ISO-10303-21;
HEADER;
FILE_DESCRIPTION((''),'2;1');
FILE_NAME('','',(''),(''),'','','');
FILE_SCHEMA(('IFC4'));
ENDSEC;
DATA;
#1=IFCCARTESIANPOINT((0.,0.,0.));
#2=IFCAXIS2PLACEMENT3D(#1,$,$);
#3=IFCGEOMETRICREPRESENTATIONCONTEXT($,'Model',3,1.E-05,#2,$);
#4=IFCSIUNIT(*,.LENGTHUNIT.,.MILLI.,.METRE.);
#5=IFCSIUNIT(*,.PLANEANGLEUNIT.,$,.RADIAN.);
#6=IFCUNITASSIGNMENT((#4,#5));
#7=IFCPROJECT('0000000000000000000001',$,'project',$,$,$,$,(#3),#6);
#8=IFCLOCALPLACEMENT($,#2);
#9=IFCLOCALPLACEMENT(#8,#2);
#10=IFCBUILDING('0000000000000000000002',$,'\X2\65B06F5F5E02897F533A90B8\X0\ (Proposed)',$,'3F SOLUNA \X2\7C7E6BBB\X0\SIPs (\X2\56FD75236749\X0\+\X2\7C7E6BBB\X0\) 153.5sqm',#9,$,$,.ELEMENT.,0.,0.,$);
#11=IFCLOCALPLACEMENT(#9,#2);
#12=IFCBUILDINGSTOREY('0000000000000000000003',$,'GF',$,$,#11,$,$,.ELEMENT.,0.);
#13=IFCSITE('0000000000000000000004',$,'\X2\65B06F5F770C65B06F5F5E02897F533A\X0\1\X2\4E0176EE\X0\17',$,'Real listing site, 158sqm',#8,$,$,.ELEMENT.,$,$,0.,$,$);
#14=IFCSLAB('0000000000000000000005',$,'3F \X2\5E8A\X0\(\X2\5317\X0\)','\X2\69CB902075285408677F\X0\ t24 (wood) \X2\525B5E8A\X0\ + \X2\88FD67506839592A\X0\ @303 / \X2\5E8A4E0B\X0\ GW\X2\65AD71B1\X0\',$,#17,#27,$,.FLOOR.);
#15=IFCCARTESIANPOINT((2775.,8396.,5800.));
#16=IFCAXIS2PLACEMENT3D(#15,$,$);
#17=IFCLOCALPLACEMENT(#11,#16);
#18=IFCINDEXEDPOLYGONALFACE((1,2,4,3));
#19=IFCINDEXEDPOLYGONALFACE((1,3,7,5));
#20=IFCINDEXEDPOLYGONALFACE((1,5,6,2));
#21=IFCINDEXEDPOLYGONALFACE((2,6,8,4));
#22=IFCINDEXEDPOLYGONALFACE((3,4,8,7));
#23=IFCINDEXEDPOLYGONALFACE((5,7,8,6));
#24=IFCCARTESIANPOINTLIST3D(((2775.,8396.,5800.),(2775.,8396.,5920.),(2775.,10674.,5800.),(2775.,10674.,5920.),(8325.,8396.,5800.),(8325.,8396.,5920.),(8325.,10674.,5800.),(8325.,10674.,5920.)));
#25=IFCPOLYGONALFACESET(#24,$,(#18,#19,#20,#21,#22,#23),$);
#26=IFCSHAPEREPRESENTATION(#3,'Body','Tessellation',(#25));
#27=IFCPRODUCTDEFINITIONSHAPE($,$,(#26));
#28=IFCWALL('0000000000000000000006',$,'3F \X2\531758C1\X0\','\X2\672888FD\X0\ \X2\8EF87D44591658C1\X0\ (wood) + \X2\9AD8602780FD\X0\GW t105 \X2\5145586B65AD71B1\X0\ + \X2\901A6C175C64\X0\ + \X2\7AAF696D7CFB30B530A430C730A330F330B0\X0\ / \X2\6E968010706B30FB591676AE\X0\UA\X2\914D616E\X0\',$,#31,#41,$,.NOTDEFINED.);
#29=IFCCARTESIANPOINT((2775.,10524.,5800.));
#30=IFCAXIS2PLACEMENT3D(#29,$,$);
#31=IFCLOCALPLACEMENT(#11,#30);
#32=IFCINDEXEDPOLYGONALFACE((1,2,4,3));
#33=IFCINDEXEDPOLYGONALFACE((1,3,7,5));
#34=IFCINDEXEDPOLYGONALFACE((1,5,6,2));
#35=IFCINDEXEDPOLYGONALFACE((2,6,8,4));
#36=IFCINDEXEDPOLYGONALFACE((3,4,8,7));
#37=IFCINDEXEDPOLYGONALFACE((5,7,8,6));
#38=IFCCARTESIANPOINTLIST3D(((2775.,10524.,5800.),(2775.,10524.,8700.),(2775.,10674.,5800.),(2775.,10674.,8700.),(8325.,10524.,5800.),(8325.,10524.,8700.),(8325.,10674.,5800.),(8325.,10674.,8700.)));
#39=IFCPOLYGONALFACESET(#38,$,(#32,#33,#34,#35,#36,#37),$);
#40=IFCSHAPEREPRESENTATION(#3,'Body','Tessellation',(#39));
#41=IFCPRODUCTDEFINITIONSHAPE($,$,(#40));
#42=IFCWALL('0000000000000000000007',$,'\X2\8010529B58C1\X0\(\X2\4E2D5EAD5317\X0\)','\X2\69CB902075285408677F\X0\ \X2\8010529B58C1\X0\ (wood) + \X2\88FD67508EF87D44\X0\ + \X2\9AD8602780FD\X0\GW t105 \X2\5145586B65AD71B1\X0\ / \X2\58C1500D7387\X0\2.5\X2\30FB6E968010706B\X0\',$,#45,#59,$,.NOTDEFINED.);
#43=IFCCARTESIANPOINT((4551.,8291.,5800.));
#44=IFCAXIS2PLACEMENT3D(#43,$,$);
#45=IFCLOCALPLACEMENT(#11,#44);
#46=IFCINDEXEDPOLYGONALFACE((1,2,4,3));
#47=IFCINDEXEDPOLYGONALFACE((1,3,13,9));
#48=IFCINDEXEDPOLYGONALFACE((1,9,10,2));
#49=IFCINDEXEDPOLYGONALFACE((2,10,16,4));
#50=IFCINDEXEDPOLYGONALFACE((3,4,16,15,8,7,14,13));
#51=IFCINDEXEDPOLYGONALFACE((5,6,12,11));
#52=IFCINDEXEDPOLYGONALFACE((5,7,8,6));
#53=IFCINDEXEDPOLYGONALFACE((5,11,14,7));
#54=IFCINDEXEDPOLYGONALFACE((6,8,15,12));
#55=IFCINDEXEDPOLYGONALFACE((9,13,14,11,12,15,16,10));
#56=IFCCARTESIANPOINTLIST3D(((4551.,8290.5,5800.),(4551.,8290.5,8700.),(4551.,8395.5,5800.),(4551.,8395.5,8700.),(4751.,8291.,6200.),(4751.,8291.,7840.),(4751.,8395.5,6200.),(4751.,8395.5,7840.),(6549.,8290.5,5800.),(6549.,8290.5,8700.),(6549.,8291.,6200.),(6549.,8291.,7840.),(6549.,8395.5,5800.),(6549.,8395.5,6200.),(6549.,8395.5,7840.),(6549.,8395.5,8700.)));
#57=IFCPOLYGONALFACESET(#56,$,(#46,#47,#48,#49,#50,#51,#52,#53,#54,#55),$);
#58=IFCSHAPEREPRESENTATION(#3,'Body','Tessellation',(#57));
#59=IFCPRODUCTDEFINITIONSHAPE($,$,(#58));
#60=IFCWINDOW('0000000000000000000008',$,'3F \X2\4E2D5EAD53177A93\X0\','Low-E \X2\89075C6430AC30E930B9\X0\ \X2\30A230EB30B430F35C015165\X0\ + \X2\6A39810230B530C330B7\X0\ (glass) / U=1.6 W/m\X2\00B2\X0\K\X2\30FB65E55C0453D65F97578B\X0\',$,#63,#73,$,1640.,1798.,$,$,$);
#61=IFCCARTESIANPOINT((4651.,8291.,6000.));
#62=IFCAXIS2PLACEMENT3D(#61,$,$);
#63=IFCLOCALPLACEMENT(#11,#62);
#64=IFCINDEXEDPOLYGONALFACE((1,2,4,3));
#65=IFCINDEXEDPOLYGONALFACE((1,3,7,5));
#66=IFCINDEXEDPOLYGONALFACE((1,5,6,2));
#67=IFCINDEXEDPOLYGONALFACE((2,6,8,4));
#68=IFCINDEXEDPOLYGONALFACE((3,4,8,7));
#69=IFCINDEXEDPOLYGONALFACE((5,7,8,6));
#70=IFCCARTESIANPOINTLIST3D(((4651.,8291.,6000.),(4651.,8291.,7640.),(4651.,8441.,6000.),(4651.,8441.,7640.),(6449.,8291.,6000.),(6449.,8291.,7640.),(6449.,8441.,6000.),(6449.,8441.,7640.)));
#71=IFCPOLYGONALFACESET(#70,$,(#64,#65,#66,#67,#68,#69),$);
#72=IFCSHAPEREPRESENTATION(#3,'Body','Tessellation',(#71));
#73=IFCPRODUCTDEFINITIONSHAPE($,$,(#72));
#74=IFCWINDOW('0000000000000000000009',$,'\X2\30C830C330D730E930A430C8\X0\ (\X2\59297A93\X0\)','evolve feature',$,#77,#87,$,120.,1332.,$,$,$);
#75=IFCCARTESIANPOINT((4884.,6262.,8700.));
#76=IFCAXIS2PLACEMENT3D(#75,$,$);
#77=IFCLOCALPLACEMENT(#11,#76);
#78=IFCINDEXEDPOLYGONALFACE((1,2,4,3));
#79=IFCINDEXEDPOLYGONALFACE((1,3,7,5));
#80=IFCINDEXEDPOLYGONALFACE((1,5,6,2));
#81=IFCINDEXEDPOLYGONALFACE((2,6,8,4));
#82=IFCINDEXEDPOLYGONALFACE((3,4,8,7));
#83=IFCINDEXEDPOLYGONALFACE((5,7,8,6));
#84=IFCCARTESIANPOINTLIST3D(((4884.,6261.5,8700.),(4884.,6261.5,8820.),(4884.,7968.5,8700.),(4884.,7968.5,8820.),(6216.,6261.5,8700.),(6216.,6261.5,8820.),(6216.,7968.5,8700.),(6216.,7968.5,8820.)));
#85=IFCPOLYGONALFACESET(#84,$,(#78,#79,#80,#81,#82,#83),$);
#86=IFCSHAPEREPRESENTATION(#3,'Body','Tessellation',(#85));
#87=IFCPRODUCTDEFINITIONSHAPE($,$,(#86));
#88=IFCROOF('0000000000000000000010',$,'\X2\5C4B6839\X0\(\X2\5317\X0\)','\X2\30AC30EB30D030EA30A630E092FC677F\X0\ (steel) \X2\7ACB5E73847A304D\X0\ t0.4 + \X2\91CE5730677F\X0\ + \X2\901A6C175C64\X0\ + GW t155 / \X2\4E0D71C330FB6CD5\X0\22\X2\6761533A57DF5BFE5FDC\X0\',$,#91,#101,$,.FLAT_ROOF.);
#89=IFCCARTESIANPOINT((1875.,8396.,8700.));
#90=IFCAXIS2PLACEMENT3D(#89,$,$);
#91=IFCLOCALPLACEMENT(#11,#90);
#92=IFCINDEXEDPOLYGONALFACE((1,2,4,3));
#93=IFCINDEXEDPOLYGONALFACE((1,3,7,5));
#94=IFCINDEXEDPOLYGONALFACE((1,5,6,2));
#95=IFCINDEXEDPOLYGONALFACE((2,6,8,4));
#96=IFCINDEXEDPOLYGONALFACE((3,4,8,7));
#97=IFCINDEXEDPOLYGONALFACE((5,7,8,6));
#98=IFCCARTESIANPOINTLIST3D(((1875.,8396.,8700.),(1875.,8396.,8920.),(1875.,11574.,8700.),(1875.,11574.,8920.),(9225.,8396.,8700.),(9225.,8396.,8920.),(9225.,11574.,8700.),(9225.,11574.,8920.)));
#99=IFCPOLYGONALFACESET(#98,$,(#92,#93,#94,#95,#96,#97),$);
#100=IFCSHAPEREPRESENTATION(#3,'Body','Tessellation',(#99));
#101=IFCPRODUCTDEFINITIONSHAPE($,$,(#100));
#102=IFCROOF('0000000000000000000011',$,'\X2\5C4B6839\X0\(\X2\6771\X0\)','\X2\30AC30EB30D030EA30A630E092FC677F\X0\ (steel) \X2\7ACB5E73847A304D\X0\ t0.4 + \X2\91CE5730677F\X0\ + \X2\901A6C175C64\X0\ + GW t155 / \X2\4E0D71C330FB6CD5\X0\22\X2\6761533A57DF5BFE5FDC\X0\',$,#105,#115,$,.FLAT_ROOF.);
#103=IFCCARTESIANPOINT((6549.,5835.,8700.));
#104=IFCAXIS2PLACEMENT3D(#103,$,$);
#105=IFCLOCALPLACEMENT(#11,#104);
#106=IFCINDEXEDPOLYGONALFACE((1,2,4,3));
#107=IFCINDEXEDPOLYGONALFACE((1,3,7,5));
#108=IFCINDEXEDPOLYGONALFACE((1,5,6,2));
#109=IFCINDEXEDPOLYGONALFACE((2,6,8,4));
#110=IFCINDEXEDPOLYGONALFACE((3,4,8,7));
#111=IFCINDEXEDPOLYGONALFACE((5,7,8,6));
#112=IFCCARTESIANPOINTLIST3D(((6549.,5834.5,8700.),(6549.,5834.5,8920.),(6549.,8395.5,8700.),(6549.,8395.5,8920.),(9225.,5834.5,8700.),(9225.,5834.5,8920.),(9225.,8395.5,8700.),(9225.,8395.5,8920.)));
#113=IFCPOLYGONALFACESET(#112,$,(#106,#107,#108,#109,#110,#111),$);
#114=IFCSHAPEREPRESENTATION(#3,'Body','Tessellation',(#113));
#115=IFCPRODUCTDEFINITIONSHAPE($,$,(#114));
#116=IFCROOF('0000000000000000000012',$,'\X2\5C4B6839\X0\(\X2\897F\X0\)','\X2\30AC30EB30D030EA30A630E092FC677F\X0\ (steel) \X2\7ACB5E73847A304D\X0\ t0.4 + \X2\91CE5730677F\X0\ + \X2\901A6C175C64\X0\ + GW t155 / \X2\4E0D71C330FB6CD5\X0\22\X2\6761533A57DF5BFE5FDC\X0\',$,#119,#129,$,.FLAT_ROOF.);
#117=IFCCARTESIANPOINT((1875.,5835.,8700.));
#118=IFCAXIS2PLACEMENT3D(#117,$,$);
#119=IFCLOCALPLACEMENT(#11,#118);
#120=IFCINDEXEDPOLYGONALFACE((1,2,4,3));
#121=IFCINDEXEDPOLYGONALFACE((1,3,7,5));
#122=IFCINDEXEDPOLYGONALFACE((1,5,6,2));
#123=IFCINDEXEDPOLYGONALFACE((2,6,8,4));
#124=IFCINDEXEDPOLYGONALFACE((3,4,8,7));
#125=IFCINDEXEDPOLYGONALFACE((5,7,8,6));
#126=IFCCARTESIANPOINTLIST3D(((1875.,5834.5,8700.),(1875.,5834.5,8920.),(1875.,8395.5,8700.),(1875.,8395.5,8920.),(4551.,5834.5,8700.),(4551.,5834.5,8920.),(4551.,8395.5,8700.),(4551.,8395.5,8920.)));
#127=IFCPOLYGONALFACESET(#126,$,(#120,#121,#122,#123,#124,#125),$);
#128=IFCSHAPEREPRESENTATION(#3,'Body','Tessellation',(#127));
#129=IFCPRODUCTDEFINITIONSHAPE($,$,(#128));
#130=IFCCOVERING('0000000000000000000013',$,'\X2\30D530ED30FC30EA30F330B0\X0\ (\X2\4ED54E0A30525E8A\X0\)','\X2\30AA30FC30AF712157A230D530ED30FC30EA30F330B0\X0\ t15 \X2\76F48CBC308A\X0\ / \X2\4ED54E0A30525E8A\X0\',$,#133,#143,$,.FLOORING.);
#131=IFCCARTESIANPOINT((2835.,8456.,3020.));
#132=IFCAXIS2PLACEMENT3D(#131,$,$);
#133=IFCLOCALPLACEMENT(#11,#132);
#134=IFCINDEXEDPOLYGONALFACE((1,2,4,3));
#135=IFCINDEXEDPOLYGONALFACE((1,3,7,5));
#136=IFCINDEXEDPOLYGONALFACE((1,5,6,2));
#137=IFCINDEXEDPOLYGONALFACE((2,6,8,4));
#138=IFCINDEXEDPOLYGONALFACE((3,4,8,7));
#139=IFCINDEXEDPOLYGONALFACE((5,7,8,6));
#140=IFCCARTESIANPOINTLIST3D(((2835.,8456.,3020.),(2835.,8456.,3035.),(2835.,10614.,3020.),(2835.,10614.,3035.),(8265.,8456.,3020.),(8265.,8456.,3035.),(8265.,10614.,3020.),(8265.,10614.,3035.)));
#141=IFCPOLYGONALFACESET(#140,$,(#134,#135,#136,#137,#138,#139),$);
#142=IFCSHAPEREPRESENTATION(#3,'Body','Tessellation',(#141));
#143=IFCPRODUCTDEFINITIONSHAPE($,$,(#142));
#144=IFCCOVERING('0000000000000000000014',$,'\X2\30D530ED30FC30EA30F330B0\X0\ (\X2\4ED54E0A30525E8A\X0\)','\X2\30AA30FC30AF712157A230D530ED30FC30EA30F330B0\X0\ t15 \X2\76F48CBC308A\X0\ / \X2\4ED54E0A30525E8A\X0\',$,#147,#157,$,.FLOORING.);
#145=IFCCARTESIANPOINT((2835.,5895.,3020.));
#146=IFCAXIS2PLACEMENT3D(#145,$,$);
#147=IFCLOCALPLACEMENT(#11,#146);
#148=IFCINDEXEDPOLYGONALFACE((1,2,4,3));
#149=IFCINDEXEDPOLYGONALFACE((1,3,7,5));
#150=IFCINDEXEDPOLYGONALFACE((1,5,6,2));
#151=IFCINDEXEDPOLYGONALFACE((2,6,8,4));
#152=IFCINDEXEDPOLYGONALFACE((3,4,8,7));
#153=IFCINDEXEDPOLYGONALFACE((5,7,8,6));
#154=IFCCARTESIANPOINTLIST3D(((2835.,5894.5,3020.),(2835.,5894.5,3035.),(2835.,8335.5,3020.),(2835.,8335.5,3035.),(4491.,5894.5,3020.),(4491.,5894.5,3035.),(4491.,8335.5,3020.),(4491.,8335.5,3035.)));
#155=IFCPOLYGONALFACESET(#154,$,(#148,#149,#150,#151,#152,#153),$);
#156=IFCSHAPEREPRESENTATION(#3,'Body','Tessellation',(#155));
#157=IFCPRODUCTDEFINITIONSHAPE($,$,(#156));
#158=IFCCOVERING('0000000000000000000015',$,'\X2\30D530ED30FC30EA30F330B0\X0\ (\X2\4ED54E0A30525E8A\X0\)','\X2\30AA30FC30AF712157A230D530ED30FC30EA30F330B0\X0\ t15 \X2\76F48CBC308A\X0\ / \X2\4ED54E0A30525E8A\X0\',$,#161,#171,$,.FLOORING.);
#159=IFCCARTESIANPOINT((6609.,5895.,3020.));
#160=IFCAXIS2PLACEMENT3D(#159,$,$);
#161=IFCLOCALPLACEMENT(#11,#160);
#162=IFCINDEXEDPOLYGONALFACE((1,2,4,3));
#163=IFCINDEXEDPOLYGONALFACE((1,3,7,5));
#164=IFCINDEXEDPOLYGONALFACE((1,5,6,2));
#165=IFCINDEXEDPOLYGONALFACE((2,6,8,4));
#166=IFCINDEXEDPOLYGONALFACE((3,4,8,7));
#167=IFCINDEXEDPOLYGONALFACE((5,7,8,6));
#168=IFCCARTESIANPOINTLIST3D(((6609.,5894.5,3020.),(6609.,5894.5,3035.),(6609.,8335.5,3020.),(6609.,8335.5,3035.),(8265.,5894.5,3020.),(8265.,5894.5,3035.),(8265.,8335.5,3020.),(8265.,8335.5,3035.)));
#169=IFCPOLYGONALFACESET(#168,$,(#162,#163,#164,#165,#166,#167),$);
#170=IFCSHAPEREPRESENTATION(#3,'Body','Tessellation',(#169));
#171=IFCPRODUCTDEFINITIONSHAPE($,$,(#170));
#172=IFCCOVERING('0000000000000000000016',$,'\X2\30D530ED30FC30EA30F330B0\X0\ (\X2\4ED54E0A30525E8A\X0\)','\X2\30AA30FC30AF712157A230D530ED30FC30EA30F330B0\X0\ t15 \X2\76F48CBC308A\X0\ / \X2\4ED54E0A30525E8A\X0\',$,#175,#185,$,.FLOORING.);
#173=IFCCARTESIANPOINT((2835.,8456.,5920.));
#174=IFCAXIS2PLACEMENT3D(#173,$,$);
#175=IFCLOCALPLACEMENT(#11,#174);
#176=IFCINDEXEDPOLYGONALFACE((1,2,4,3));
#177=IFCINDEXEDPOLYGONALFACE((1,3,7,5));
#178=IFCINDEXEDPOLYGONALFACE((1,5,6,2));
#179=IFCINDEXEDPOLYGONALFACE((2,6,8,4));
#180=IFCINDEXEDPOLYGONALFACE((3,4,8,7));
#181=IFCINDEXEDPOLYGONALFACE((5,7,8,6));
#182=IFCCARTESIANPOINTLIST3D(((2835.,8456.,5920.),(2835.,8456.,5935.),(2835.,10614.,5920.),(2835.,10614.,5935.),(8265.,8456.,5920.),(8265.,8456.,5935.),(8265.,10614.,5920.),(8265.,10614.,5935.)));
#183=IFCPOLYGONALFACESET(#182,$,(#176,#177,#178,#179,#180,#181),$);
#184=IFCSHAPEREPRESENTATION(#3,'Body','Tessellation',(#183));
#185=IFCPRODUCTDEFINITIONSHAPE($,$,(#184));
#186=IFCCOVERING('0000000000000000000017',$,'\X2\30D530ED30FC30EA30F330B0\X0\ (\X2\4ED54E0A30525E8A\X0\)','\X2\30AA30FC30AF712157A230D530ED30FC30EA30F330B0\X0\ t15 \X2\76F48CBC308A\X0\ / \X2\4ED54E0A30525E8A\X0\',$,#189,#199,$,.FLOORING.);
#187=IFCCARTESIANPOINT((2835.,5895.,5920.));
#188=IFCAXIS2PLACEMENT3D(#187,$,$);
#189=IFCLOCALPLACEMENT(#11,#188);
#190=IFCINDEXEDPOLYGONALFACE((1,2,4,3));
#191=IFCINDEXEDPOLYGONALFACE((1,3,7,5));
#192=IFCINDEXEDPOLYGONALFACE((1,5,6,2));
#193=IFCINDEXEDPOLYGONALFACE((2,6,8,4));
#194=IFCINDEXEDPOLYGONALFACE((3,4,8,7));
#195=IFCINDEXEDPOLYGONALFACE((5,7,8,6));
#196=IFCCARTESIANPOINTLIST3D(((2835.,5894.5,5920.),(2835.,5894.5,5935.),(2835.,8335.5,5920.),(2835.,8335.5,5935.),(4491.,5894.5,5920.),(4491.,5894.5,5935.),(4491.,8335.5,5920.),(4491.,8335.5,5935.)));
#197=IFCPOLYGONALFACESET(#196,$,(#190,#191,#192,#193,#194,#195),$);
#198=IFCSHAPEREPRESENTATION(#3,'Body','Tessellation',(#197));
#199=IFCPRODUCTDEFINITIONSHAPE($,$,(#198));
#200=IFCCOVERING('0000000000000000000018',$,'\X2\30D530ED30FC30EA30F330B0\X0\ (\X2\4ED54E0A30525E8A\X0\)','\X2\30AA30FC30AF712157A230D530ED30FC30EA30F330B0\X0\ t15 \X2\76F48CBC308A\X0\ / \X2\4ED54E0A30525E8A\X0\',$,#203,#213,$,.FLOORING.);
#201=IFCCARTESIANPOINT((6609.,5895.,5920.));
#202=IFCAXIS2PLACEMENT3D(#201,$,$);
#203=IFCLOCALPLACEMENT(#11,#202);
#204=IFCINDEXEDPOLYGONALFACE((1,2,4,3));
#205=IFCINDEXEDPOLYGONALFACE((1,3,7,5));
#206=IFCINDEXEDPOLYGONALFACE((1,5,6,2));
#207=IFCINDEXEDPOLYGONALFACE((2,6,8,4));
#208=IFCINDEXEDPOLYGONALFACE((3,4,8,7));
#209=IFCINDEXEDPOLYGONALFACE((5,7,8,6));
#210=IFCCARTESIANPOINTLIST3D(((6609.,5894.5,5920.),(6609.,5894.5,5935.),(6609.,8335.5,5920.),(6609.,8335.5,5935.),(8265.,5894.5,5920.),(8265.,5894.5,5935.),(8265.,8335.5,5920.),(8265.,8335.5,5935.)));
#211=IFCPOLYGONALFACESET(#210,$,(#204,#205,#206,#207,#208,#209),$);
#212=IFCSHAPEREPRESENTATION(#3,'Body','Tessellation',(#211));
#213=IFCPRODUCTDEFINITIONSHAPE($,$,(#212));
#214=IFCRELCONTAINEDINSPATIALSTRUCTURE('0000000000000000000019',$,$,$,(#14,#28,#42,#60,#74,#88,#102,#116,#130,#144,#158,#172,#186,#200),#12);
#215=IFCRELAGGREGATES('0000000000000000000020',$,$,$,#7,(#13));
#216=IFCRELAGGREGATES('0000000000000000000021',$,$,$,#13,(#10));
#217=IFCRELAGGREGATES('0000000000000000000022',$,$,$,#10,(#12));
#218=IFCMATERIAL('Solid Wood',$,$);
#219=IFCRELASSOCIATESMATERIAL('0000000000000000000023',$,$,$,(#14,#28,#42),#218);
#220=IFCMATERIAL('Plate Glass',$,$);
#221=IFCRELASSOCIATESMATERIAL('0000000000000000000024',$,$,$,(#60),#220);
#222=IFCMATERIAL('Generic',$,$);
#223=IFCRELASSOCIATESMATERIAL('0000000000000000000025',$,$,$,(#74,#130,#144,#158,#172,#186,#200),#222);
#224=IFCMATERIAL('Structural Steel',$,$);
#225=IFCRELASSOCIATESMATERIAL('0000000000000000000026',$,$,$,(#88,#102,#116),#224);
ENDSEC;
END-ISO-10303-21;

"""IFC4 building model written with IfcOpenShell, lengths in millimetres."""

from ifc_helpers import new_model, si_unit, frame, frame_2d, origin, place, context, project, spatial, rectangle, extrude, material, element, fill, save


model = new_model("IFC4")

# Units and contexts
model_context = context("Model", 3, precision=1e-05, world=origin())
ifc_project = project(units=[si_unit("LENGTHUNIT", "METRE", prefix="MILLI"), si_unit("PLANEANGLEUNIT", "RADIAN")], contexts=[model_context])

# Site, building, storey
site_placement = place(None, origin())
site = spatial("IfcSite", under=ifc_project, at=site_placement, Name="新潟県新潟市西区1丁目17", ObjectType="Real listing site, 158sqm", CompositionType="ELEMENT", RefElevation=0.0)
building_placement = place(site_placement, origin())
building = spatial("IfcBuilding", under=site, at=building_placement, Name="新潟市西区邸 (Proposed)", ObjectType="3F SOLUNA 籾殻SIPs (国産杉+籾殻) 153.5sqm", CompositionType="ELEMENT", ElevationOfRefHeight=0.0, ElevationOfTerrain=0.0)
storey_placement = place(building_placement, origin())
storey = spatial("IfcBuildingStorey", under=building, at=storey_placement, Name="GF", CompositionType="ELEMENT", Elevation=0.0)

# Slab
ifc_material_1 = material(Name="Solid Wood")
slab_placement = place(storey_placement, frame((2775.0, 8396.0, 5800.0)))
element("IfcSlab", 1, at=slab_placement, inside=storey, material=ifc_material_1, Name="3F 床(北)", Description="構造用合板 t24 (wood) 剛床 + 製材根太 @303 / 床下 GW断熱", PredefinedType="FLOOR", context=model_context, shape_type="SweptSolid", body=[
    extrude(rectangle(XDim=5550.0, YDim=2278.0, at=frame_2d((2775.0, 1139.0))), frame((2775.0, 8396.0, 5800.0)), (0.0, 0.0, 1.0), 120.0),
])

# Wall
wall_1_placement = place(storey_placement, frame((2775.0, 10524.0, 5800.0)))
element("IfcWall", 2, at=wall_1_placement, inside=storey, material=ifc_material_1, Name="3F 北壁", Description="木製 軸組外壁 (wood) + 高性能GW t105 充填断熱 + 通気層 + 窯業系サイディング / 準耐火・外皮UA配慮", PredefinedType="NOTDEFINED", context=model_context, shape_type="SweptSolid", body=[
    extrude(rectangle(XDim=5550.0, YDim=150.0, at=frame_2d((2775.0, 75.0))), frame((2775.0, 10524.0, 5800.0)), (0.0, 0.0, 1.0), 2900.0),
])

# Wall, opening, window
wall_2_placement = place(storey_placement, frame((4551.0, 8291.0, 5800.0)))
wall_2 = element("IfcWall", 3, at=wall_2_placement, inside=storey, material=ifc_material_1, Name="耐力壁(中庭北)", Description="構造用合板 耐力壁 (wood) + 製材軸組 + 高性能GW t105 充填断熱 / 壁倍率2.5・準耐火", PredefinedType="NOTDEFINED", context=model_context, shape_type="SweptSolid", body=[
    extrude(rectangle(XDim=1998.0, YDim=105.0, at=frame_2d((999.0, 52.0))), frame((4551.0, 8291.0, 5800.0)), (0.0, 0.0, 1.0), 2900.0),
])
opening_placement = place(storey_placement, frame((4651.0, 8291.0, 6000.0)))
opening = element("IfcOpeningElement", 4, at=opening_placement, cuts=wall_2, PredefinedType="NOTDEFINED", context=model_context, shape_type="SweptSolid", body=[
    extrude(rectangle(XDim=1798.0, YDim=150.0, at=frame_2d((899.0, 75.0))), frame((4651.0, 8291.0, 6000.0)), (0.0, 0.0, 1.0), 1640.0),
])
ifc_material_2 = material(Name="Plate Glass")
window_1_placement = place(storey_placement, frame((4651.0, 8291.0, 6000.0)))
window_1 = element("IfcWindow", 5, at=window_1_placement, inside=storey, material=ifc_material_2, Name="3F 中庭北窓", Description="Low-E 複層ガラス アルゴン封入 + 樹脂サッシ (glass) / U=1.6 W/m²K・日射取得型", OverallHeight=1640.0, OverallWidth=1798.0, context=model_context, shape_type="SweptSolid", body=[
    extrude(rectangle(XDim=1798.0, YDim=150.0, at=frame_2d((899.0, 75.0))), frame((4651.0, 8291.0, 6000.0)), (0.0, 0.0, 1.0), 1640.0),
])
fill(opening, window_1)

# Window
ifc_material_3 = material(Name="Generic")
window_2_placement = place(storey_placement, frame((4884.0, 6262.0, 8700.0)))
element("IfcWindow", 6, at=window_2_placement, inside=storey, material=ifc_material_3, Name="トップライト (天窓)", Description="evolve feature", OverallHeight=120.0, OverallWidth=1332.0, context=model_context, shape_type="SweptSolid", body=[
    extrude(rectangle(XDim=1332.0, YDim=1707.0, at=frame_2d((666.0, 853.0))), frame((4884.0, 6262.0, 8700.0)), (0.0, 0.0, 1.0), 120.0),
])

# Roofs
ifc_material_4 = material(Name="Structural Steel")
roof_1_placement = place(storey_placement, frame((1875.0, 8396.0, 8700.0)))
element("IfcRoof", 7, at=roof_1_placement, inside=storey, material=ifc_material_4, Name="屋根(北)", Description="ガルバリウム鋼板 (steel) 立平葺き t0.4 + 野地板 + 通気層 + GW t155 / 不燃・法22条区域対応", PredefinedType="FLAT_ROOF", context=model_context, shape_type="SweptSolid", body=[
    extrude(rectangle(XDim=7350.0, YDim=3178.0, at=frame_2d((3675.0, 1589.0))), frame((1875.0, 8396.0, 8700.0)), (0.0, 0.0, 1.0), 220.0),
])
roof_2_placement = place(storey_placement, frame((6549.0, 5835.0, 8700.0)))
element("IfcRoof", 8, at=roof_2_placement, inside=storey, material=ifc_material_4, Name="屋根(東)", Description="ガルバリウム鋼板 (steel) 立平葺き t0.4 + 野地板 + 通気層 + GW t155 / 不燃・法22条区域対応", PredefinedType="FLAT_ROOF", context=model_context, shape_type="SweptSolid", body=[
    extrude(rectangle(XDim=2676.0, YDim=2561.0, at=frame_2d((1338.0, 1280.0))), frame((6549.0, 5835.0, 8700.0)), (0.0, 0.0, 1.0), 220.0),
])
roof_3_placement = place(storey_placement, frame((1875.0, 5835.0, 8700.0)))
element("IfcRoof", 9, at=roof_3_placement, inside=storey, material=ifc_material_4, Name="屋根(西)", Description="ガルバリウム鋼板 (steel) 立平葺き t0.4 + 野地板 + 通気層 + GW t155 / 不燃・法22条区域対応", PredefinedType="FLAT_ROOF", context=model_context, shape_type="SweptSolid", body=[
    extrude(rectangle(XDim=2676.0, YDim=2561.0, at=frame_2d((1338.0, 1280.0))), frame((1875.0, 5835.0, 8700.0)), (0.0, 0.0, 1.0), 220.0),
])

# Coverings
covering_1_placement = place(storey_placement, frame((2835.0, 8456.0, 3020.0)))
element("IfcCovering", 10, at=covering_1_placement, inside=storey, material=ifc_material_3, Name="フローリング (仕上げ床)", Description="オーク無垢フローリング t15 直貼り / 仕上げ床", PredefinedType="FLOORING", context=model_context, shape_type="SweptSolid", body=[
    extrude(rectangle(XDim=5430.0, YDim=2158.0, at=frame_2d((2715.0, 1079.0))), frame((2835.0, 8456.0, 3020.0)), (0.0, 0.0, 1.0), 15.0),
])
covering_2_placement = place(storey_placement, frame((2835.0, 5895.0, 3020.0)))
element("IfcCovering", 11, at=covering_2_placement, inside=storey, material=ifc_material_3, Name="フローリング (仕上げ床)", Description="オーク無垢フローリング t15 直貼り / 仕上げ床", PredefinedType="FLOORING", context=model_context, shape_type="SweptSolid", body=[
    extrude(rectangle(XDim=1656.0, YDim=2441.0, at=frame_2d((828.0, 1220.0))), frame((2835.0, 5895.0, 3020.0)), (0.0, 0.0, 1.0), 15.0),
])
covering_3_placement = place(storey_placement, frame((6609.0, 5895.0, 3020.0)))
element("IfcCovering", 12, at=covering_3_placement, inside=storey, material=ifc_material_3, Name="フローリング (仕上げ床)", Description="オーク無垢フローリング t15 直貼り / 仕上げ床", PredefinedType="FLOORING", context=model_context, shape_type="SweptSolid", body=[
    extrude(rectangle(XDim=1656.0, YDim=2441.0, at=frame_2d((828.0, 1220.0))), frame((6609.0, 5895.0, 3020.0)), (0.0, 0.0, 1.0), 15.0),
])
covering_4_placement = place(storey_placement, frame((2835.0, 8456.0, 5920.0)))
element("IfcCovering", 13, at=covering_4_placement, inside=storey, material=ifc_material_3, Name="フローリング (仕上げ床)", Description="オーク無垢フローリング t15 直貼り / 仕上げ床", PredefinedType="FLOORING", context=model_context, shape_type="SweptSolid", body=[
    extrude(rectangle(XDim=5430.0, YDim=2158.0, at=frame_2d((2715.0, 1079.0))), frame((2835.0, 8456.0, 5920.0)), (0.0, 0.0, 1.0), 15.0),
])
covering_5_placement = place(storey_placement, frame((2835.0, 5895.0, 5920.0)))
element("IfcCovering", 14, at=covering_5_placement, inside=storey, material=ifc_material_3, Name="フローリング (仕上げ床)", Description="オーク無垢フローリング t15 直貼り / 仕上げ床", PredefinedType="FLOORING", context=model_context, shape_type="SweptSolid", body=[
    extrude(rectangle(XDim=1656.0, YDim=2441.0, at=frame_2d((828.0, 1220.0))), frame((2835.0, 5895.0, 5920.0)), (0.0, 0.0, 1.0), 15.0),
])
covering_6_placement = place(storey_placement, frame((6609.0, 5895.0, 5920.0)))
element("IfcCovering", 15, at=covering_6_placement, inside=storey, material=ifc_material_3, Name="フローリング (仕上げ床)", Description="オーク無垢フローリング t15 直貼り / 仕上げ床", PredefinedType="FLOORING", context=model_context, shape_type="SweptSolid", body=[
    extrude(rectangle(XDim=1656.0, YDim=2441.0, at=frame_2d((828.0, 1220.0))), frame((6609.0, 5895.0, 5920.0)), (0.0, 0.0, 1.0), 15.0),
])

save(model, "model.ifc")
